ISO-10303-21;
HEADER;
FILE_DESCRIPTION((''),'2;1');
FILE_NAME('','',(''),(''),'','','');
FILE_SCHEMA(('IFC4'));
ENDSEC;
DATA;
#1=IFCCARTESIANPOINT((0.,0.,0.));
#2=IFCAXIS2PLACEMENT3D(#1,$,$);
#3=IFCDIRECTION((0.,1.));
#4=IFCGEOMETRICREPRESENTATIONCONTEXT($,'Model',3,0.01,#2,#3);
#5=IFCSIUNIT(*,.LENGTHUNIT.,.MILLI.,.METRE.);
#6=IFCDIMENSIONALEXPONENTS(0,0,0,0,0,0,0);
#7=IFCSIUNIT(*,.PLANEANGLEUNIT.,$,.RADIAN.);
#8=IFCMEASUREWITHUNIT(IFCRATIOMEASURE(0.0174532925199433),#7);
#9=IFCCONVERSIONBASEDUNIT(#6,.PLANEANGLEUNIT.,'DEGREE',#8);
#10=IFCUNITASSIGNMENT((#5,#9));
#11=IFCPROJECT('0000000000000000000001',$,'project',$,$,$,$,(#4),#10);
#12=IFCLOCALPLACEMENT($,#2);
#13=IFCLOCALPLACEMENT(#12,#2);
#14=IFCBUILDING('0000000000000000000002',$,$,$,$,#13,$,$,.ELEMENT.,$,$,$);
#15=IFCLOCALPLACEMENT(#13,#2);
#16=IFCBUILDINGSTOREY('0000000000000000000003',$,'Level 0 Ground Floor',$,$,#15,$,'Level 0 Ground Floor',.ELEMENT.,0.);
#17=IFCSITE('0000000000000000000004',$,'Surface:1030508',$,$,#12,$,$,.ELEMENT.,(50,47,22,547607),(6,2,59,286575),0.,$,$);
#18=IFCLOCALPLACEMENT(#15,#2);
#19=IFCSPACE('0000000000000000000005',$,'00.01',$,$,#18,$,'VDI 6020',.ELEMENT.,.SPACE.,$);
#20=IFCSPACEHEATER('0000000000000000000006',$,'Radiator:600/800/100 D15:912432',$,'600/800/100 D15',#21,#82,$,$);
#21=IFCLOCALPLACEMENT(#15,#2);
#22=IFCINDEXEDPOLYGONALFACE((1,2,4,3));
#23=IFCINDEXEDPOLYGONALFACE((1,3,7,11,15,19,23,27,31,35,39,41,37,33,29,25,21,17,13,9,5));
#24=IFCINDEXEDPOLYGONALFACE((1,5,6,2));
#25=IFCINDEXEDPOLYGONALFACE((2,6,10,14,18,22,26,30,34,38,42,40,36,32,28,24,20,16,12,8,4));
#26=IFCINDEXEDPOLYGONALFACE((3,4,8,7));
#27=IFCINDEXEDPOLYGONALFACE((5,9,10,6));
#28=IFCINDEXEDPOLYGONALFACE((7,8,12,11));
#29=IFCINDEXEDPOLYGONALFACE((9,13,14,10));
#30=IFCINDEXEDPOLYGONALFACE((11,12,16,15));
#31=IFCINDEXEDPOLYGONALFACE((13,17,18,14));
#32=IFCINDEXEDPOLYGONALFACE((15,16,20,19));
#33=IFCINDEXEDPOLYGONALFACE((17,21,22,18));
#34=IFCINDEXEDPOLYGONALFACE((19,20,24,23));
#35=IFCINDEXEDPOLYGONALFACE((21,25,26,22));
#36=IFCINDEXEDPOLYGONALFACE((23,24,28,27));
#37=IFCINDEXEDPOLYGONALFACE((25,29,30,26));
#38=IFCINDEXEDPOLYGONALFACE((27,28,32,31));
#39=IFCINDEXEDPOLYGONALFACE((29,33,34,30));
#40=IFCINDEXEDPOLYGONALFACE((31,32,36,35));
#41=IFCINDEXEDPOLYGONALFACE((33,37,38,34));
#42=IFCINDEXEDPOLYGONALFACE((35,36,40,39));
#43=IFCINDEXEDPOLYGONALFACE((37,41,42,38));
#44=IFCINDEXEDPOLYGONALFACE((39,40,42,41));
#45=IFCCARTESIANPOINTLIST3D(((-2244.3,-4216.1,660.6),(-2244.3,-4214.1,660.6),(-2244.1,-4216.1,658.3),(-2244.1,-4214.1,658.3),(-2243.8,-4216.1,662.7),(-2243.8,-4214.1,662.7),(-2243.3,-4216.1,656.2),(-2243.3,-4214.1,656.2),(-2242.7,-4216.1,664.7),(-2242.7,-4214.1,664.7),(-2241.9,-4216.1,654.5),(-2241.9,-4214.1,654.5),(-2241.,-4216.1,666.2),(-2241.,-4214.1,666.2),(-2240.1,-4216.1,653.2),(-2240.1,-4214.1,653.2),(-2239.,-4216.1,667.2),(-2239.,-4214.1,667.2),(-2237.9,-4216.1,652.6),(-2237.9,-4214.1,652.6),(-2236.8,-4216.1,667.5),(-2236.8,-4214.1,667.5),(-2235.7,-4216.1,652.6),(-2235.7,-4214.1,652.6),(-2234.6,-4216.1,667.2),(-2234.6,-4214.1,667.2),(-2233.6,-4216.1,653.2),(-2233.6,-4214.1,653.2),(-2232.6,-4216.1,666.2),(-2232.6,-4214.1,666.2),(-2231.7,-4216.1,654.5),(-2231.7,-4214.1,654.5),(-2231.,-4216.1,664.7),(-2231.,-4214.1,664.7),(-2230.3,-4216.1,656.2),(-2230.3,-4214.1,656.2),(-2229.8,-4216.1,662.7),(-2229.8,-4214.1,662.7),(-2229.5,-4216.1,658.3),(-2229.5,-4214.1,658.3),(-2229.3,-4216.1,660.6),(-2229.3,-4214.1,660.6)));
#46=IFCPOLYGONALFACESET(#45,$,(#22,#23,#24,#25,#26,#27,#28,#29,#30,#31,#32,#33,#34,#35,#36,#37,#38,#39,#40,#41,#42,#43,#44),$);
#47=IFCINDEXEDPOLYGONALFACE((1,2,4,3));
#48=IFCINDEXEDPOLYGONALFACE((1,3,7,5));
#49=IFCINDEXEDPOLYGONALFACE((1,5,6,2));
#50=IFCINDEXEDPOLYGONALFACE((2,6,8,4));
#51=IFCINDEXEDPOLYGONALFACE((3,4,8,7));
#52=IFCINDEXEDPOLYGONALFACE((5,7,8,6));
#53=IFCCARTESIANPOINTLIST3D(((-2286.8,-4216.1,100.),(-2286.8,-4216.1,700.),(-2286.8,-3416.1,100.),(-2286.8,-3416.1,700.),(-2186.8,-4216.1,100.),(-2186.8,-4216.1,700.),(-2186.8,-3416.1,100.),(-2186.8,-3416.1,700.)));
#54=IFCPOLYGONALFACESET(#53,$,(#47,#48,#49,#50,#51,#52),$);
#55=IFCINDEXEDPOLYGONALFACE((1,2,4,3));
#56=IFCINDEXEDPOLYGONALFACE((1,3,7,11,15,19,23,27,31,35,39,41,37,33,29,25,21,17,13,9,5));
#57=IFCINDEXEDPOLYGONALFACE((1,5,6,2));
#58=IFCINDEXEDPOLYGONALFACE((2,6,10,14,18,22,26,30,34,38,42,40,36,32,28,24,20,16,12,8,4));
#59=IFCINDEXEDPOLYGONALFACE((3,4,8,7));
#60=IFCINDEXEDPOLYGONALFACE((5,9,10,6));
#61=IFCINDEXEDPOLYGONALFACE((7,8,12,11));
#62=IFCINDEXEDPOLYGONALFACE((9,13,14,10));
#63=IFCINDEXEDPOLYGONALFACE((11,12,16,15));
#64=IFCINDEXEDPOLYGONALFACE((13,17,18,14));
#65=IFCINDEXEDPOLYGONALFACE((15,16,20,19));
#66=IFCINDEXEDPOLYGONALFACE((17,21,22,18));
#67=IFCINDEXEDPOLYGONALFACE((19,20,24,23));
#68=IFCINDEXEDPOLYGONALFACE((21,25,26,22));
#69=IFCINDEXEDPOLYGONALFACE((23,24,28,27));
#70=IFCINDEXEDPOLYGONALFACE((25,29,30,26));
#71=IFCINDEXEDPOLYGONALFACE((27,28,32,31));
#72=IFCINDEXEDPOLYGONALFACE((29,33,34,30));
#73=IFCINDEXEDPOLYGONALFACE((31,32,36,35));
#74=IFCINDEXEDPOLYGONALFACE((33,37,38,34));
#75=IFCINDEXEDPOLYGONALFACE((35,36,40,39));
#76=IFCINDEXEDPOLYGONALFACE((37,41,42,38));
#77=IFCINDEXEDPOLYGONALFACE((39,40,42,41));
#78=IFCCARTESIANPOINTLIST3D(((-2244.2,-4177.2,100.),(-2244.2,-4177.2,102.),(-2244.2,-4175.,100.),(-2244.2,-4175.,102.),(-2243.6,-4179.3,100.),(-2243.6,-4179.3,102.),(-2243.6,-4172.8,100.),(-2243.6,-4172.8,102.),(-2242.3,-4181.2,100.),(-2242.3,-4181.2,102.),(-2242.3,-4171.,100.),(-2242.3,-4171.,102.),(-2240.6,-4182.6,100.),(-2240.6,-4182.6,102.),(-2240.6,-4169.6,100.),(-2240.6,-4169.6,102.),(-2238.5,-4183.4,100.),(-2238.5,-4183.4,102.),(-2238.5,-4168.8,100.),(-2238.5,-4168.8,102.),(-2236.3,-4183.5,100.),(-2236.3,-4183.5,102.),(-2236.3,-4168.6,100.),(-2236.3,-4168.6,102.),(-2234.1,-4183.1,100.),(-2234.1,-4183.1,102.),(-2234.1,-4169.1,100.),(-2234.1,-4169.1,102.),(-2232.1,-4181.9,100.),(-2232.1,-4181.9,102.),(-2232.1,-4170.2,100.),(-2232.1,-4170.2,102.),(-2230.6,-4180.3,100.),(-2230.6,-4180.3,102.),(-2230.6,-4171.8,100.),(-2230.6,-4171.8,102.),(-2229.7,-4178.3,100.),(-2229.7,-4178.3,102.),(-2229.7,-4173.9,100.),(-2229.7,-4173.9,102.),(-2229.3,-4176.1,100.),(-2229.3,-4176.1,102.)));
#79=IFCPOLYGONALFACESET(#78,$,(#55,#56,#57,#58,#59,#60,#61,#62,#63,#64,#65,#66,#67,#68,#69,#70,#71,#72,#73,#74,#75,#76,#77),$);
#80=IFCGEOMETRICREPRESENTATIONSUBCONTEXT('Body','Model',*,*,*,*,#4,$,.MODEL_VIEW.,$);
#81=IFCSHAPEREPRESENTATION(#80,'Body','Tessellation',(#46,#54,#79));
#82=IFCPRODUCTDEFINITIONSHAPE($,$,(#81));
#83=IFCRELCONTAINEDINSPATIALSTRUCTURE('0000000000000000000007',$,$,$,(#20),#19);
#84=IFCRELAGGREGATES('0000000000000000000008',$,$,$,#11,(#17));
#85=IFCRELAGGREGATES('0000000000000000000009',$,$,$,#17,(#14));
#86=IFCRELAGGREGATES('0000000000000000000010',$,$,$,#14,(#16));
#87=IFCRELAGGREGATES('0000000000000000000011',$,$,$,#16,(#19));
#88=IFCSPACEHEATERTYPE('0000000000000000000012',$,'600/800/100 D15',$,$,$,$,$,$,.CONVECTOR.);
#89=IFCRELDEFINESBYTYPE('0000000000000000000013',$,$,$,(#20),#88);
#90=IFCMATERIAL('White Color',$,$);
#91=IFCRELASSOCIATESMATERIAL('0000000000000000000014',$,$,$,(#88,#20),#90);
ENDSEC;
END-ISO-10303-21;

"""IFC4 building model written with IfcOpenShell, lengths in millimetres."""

from ifc_helpers import new_model, entity, si_unit, converted_unit, direction, frame, frame_2d, origin, place, context, subcontext, project, spatial, rectangle, circle, extrude, source, transform, mapped, material, type_object, type_shapes, element, save


model = new_model("IFC4")

# Units and contexts
model_context = context("Model", 3, precision=0.01, world=origin(), true_north=direction((0.0, 1.0)))
body_context = subcontext(model_context, "Body", "Model", "MODEL_VIEW")
ifc_project = project(units=[si_unit("LENGTHUNIT", "METRE", prefix="MILLI"), converted_unit("PLANEANGLEUNIT", "DEGREE", entity("IfcRatioMeasure", 0.0174532925199433), si_unit("PLANEANGLEUNIT", "RADIAN"), dimensions=[0, 0, 0, 0, 0, 0, 0])], contexts=[model_context])

# Site, building, storey
site_placement = place(None, origin())
site = spatial("IfcSite", under=ifc_project, at=site_placement, Name="Surface:1030508", CompositionType="ELEMENT", RefLatitude=(50, 47, 22, 547607), RefLongitude=(6, 2, 59, 286575), RefElevation=0.0)
building_placement = place(site_placement, origin())
building = spatial("IfcBuilding", under=site, at=building_placement, CompositionType="ELEMENT")
storey_placement = place(building_placement, origin())
storey = spatial("IfcBuildingStorey", under=building, at=storey_placement, Name="Level 0 Ground Floor", LongName="Level 0 Ground Floor", CompositionType="ELEMENT", Elevation=0.0)

# Shared definitions
space_placement = place(storey_placement, origin())
space = spatial("IfcSpace", under=storey, at=space_placement, Name="00.01", LongName="VDI 6020", CompositionType="ELEMENT", PredefinedType="SPACE")

# Space heater
ifc_material_1 = material(Name="White Color")
space_heater_type = type_object("IfcSpaceHeaterType", Name="600/800/100 D15", PredefinedType="CONVECTOR", material=ifc_material_1)
shared_shape_1 = source(origin(), body_context, "Body", "SweptSolid", [
    extrude(circle(Radius=7.5, at=frame_2d((0.0, 0.0), x_axis=(1.0, 0.0))), frame((798.0, 50.0, 560.0), z_axis=(1.0, 0.0, 0.0), x_axis=(0.0, 0.0, 1.0)), (0.0, 0.0, 1.0), 2.0),
    extrude(rectangle(XDim=100.0, YDim=800.0, at=frame_2d((0.0, 0.0), x_axis=(1.0, 0.0))), frame((400.0, 50.0, 0.0), z_axis=(0.0, 0.0, 1.0), x_axis=(0.0, 1.0, 0.0)), (0.0, 0.0, 1.0), 600.0),
    extrude(circle(Radius=7.5, at=frame_2d((0.0, 0.0), x_axis=(1.0, 0.0))), frame((760.0, 50.0, 0.0), z_axis=(0.0, 0.0, 1.0), x_axis=(0.0, 1.0, 0.0)), (0.0, 0.0, 1.0), 2.0),
])
type_shapes(space_heater_type, [shared_shape_1])
space_heater_placement = place(space_placement, frame((-2286.8, -3416.1, 100.0), z_axis=(0.0, 0.0, 1.0), x_axis=(0.0, -1.0, 0.0)))
element("IfcSpaceHeater", 1, at=space_heater_placement, inside=space, type_object=space_heater_type, material=ifc_material_1, Name="Radiator:600/800/100 D15:912432", ObjectType="600/800/100 D15", context=body_context, shape_type="MappedRepresentation", body=[
    mapped(shared_shape_1, transform((0.0, 0.0, 0.0), scale=1.0)),
])

save(model, "model.ifc")
